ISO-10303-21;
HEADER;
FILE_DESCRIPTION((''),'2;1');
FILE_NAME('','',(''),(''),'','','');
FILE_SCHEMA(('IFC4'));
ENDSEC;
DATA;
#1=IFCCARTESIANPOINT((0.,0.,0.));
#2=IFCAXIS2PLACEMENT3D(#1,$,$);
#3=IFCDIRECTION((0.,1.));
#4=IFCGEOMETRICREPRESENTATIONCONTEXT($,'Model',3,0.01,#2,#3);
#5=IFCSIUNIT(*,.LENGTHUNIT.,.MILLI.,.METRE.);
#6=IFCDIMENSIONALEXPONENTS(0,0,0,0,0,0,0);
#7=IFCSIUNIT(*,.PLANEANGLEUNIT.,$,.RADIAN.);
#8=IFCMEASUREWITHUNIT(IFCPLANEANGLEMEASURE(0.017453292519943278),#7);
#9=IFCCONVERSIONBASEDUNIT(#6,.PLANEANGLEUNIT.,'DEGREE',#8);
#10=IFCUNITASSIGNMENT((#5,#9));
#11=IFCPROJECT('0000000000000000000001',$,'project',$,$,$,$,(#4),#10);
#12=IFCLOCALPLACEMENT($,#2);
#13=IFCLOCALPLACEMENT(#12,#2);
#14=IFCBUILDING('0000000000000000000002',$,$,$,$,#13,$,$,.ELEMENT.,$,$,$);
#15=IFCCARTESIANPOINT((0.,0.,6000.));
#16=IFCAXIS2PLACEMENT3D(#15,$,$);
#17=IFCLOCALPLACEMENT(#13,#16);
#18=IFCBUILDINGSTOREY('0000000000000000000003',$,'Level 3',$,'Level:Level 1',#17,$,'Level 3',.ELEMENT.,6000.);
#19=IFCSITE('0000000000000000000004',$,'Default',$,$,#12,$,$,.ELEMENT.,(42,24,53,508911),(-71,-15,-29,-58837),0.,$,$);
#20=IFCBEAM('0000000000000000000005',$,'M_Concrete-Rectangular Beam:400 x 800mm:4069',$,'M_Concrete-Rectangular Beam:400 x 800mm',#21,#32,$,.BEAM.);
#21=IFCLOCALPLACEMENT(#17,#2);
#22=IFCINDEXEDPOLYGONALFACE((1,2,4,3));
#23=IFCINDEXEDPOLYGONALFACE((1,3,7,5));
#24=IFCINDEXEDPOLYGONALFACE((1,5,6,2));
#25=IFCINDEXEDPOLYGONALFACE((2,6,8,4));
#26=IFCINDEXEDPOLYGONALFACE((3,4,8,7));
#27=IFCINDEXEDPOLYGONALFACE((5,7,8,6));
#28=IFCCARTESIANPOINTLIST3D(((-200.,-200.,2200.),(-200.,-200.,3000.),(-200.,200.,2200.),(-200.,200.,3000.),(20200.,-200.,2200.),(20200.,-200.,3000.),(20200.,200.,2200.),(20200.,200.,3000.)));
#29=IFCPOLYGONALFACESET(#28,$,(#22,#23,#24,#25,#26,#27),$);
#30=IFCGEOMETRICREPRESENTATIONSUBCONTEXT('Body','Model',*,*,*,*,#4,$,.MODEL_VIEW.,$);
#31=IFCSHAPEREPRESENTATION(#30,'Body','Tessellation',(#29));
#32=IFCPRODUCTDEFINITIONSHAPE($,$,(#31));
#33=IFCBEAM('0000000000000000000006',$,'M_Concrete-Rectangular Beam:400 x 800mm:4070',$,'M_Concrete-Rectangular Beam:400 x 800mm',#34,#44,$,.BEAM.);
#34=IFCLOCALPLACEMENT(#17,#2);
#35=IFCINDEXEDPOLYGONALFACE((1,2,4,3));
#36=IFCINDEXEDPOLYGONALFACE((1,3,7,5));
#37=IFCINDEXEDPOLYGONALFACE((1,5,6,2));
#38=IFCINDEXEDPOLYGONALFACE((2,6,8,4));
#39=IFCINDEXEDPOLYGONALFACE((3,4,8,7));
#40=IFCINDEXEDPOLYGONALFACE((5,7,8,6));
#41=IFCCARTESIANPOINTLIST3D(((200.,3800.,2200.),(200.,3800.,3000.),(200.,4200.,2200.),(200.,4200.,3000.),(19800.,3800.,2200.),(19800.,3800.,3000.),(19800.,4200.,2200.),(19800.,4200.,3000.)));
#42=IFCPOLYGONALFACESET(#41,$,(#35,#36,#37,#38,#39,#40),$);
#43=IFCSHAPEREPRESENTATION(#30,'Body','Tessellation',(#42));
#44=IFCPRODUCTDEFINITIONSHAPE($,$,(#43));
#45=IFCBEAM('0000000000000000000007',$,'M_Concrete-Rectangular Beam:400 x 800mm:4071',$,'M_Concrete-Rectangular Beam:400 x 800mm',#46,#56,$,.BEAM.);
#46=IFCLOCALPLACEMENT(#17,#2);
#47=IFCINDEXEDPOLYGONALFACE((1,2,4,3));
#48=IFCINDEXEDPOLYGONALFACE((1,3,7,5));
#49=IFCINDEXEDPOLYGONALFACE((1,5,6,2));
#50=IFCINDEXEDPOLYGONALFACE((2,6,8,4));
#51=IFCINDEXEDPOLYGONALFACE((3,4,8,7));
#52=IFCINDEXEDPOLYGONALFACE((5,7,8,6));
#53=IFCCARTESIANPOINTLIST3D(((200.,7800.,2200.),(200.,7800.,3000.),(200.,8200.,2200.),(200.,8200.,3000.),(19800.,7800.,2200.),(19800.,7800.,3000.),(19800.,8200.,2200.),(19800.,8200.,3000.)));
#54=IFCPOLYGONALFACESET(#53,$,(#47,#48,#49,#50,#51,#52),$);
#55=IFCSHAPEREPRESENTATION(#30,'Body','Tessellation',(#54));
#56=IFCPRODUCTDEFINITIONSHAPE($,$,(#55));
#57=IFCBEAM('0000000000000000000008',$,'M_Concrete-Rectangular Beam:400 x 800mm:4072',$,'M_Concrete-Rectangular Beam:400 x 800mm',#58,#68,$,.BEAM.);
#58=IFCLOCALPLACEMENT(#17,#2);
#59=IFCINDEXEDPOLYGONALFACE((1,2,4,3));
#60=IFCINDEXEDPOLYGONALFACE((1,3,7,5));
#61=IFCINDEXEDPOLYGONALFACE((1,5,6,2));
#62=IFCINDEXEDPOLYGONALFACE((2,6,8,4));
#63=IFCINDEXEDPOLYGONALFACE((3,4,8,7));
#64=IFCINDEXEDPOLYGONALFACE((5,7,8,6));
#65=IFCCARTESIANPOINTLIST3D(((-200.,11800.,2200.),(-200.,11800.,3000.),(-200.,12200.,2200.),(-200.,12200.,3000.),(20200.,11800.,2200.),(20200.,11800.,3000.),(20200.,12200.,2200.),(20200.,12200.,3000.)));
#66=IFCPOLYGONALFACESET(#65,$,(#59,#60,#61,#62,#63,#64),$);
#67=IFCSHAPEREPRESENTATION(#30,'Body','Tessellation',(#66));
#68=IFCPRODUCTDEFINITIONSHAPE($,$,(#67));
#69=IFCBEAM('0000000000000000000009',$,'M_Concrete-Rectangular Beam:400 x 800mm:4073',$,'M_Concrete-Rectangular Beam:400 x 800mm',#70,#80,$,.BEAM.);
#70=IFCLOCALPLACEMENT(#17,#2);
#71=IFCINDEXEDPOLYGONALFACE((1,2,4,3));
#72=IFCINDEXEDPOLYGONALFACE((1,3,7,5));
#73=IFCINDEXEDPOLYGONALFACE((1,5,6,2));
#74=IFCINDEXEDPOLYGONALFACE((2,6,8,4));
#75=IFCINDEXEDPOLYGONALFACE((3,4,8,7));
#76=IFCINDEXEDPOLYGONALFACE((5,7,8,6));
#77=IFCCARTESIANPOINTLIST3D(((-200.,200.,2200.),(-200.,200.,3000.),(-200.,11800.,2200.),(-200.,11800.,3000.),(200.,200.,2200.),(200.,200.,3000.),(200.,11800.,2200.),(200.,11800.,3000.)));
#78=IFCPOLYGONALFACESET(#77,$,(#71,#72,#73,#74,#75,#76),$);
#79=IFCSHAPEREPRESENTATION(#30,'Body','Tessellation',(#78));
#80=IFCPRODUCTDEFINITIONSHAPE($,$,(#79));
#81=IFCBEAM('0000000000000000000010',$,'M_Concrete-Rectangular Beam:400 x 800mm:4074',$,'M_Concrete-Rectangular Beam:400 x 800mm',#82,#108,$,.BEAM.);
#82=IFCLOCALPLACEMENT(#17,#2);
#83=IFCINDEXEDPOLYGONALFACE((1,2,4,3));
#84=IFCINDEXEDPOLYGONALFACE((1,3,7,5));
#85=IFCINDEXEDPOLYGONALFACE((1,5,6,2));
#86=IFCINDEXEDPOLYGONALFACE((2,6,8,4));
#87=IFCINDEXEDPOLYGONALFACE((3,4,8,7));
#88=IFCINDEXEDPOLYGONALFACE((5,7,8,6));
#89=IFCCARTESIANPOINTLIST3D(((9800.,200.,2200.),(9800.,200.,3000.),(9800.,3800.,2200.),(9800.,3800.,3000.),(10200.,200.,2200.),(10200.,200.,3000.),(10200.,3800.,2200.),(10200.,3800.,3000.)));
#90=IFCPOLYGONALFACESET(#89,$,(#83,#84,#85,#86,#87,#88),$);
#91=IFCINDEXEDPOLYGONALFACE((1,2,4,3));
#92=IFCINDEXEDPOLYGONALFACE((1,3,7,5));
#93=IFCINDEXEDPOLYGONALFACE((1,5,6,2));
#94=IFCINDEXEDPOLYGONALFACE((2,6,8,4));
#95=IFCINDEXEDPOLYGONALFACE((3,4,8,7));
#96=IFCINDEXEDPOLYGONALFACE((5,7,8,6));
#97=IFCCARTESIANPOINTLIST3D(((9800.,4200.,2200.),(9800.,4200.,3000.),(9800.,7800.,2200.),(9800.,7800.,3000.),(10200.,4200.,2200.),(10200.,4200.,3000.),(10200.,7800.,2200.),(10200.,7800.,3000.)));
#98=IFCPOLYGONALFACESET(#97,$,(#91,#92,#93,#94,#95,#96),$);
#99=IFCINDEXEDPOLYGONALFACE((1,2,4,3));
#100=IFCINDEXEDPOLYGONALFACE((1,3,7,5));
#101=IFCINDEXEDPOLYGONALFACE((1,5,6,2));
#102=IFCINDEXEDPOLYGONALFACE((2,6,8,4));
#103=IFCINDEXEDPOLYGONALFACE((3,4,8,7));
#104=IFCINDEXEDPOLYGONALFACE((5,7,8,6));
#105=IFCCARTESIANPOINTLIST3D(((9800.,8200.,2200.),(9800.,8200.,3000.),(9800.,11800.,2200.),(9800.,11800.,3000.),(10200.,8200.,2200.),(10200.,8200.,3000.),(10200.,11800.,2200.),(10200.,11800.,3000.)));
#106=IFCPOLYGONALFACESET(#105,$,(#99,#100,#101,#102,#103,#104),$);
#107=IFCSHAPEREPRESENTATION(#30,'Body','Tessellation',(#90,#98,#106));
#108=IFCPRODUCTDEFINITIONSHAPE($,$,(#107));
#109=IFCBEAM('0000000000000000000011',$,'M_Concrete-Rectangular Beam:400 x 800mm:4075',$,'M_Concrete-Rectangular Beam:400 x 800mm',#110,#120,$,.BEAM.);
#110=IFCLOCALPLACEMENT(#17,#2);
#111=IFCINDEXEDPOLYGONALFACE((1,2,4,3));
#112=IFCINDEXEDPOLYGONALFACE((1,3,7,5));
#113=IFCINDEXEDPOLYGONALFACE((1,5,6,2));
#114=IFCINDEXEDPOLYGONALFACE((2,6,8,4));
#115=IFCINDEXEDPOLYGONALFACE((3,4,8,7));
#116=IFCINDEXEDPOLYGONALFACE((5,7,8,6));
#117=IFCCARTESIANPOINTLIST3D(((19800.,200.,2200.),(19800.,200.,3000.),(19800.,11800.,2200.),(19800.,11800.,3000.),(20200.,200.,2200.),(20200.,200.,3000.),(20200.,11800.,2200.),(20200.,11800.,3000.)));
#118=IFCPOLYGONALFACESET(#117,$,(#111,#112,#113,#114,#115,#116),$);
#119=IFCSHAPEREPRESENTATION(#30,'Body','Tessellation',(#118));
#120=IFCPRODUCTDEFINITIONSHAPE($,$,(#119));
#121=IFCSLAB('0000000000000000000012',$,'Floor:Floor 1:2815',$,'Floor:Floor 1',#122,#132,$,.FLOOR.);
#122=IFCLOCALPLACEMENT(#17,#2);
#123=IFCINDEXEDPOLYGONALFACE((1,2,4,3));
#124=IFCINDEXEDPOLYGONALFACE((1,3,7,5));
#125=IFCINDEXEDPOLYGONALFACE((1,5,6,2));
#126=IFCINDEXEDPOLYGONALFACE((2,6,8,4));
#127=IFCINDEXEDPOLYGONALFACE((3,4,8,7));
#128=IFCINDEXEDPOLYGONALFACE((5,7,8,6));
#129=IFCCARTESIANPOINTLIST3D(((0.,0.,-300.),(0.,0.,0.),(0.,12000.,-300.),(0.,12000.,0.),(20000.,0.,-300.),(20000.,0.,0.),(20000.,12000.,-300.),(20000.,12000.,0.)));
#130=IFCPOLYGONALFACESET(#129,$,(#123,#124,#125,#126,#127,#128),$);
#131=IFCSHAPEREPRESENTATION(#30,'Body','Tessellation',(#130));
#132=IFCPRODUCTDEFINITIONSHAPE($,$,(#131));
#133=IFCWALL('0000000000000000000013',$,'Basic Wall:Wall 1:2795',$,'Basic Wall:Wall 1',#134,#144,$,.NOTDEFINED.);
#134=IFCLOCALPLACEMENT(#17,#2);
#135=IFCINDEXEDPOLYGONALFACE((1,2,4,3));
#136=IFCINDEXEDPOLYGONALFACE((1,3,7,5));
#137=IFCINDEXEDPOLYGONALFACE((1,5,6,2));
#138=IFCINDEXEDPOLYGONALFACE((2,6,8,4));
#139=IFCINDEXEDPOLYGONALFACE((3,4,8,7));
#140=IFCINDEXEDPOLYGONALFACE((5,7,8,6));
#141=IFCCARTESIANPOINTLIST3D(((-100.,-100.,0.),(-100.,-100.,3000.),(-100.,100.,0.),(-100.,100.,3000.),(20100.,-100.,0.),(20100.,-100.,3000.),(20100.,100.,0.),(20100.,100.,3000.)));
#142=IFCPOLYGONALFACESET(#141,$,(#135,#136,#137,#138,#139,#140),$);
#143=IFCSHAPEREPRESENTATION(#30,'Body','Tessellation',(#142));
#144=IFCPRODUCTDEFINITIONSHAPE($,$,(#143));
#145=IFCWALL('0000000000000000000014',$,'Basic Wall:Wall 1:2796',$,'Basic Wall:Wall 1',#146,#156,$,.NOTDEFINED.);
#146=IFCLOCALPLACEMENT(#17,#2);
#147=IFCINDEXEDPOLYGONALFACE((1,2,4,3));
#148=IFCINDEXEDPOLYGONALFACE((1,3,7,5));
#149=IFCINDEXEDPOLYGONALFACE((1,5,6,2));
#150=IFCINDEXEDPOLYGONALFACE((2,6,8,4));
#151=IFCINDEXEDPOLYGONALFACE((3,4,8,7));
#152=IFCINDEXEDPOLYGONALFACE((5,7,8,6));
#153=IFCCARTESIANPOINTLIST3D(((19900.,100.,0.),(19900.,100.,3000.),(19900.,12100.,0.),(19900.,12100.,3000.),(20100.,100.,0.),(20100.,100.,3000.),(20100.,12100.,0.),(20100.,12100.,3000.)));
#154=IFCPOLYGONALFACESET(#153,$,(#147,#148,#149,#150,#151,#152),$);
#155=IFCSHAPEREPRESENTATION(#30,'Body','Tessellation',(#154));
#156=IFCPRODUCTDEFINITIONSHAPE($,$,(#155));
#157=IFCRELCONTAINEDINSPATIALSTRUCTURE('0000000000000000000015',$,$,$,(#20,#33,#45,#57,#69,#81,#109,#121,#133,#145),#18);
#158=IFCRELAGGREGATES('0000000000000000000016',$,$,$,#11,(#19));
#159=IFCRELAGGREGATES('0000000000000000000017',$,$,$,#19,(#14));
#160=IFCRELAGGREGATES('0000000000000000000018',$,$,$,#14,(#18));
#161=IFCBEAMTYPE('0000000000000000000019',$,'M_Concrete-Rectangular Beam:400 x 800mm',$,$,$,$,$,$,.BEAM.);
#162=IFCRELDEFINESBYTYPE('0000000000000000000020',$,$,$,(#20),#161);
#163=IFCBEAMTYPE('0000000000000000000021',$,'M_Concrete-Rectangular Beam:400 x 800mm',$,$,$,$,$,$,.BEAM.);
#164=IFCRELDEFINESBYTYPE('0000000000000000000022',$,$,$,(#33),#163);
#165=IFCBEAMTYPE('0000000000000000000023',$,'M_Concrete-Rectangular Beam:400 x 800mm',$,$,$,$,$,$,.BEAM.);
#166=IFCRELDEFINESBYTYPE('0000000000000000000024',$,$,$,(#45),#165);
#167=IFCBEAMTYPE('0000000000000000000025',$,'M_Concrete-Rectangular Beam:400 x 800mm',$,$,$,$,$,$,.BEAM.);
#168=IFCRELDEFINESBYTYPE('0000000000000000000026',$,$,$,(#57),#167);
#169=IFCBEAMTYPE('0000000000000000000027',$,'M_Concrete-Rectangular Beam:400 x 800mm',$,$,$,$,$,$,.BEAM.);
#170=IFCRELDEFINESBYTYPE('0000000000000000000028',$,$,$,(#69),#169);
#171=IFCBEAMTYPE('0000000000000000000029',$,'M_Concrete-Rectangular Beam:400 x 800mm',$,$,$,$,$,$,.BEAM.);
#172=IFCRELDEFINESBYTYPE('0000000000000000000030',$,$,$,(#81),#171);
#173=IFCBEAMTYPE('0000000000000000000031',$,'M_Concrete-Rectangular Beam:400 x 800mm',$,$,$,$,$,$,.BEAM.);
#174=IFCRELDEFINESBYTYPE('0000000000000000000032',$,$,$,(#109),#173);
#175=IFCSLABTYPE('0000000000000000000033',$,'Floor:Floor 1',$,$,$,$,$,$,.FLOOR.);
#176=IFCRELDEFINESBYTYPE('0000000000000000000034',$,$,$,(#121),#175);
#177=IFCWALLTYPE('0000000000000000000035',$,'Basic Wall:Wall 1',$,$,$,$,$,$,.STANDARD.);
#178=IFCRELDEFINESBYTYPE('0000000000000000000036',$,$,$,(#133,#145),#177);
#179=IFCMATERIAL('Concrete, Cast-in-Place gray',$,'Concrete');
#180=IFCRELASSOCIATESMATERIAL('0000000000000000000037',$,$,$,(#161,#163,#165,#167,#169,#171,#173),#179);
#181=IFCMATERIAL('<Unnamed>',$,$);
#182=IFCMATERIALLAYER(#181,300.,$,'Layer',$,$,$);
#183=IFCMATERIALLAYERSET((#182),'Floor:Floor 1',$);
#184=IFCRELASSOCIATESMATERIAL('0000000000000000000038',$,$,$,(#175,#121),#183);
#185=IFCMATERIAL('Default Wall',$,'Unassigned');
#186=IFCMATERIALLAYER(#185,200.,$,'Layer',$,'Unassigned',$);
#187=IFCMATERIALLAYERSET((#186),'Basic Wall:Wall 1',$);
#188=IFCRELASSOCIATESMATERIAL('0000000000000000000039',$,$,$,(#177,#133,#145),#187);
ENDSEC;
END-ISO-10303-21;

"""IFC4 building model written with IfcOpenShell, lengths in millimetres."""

from ifc_helpers import new_model, entity, si_unit, converted_unit, direction, frame, frame_2d, origin, origin_2d_with_axis, place, context, subcontext, project, spatial, rectangle, extrude, source, transform, mapped, material, layer, layer_set, layer_usage, material_profile, profile_set, type_object, type_shapes, element, save


model = new_model("IFC4")

# Units and contexts
model_context = context("Model", 3, precision=0.01, world=origin(), true_north=direction((0.0, 1.0)))
body_context = subcontext(model_context, "Body", "Model", "MODEL_VIEW")
ifc_project = project(units=[si_unit("LENGTHUNIT", "METRE", prefix="MILLI"), converted_unit("PLANEANGLEUNIT", "DEGREE", entity("IfcPlaneAngleMeasure", 0.017453292519943278), si_unit("PLANEANGLEUNIT", "RADIAN"), dimensions=[0, 0, 0, 0, 0, 0, 0])], contexts=[model_context])

# Site, building, storey
site_placement = place(None, origin())
site = spatial("IfcSite", under=ifc_project, at=site_placement, Name="Default", CompositionType="ELEMENT", RefLatitude=(42, 24, 53, 508911), RefLongitude=(-71, -15, -29, -58837), RefElevation=0.0)
building_placement = place(site_placement, origin())
building = spatial("IfcBuilding", under=site, at=building_placement, CompositionType="ELEMENT")
storey_placement = place(building_placement, frame((0.0, 0.0, 6000.0)))
storey = spatial("IfcBuildingStorey", under=building, at=storey_placement, Name="Level 3", ObjectType="Level:Level 1", LongName="Level 3", CompositionType="ELEMENT", Elevation=6000.0)

# Beams
ifc_material_1 = material(Name="Concrete, Cast-in-Place gray", Category="Concrete")
ifc_material_profile = material_profile(ifc_material_1, rectangle(XDim=800.0, YDim=400.0, at=origin_2d_with_axis()), Name="400 x 800mm")
ifc_profile_set = profile_set([ifc_material_profile], Name="400 x 800mm")
beam_type_1 = type_object("IfcBeamType", Name="M_Concrete-Rectangular Beam:400 x 800mm", PredefinedType="BEAM", material=ifc_profile_set)
shared_shape_1 = source(origin(), body_context, "Body", "SweptSolid", [
    extrude(rectangle(XDim=800.0, YDim=400.0, at=origin_2d_with_axis()), frame((-200.0, 0.0, 8600.0), z_axis=(1.0, 0.0, 0.0), x_axis=(0.0, 0.0, -1.0)), (0.0, 0.0, 1.0), 20400.0),
])
type_shapes(beam_type_1, [shared_shape_1])
beam_1_placement = place(storey_placement, frame((0.0, 0.0, -6000.0)))
element("IfcBeam", 1, at=beam_1_placement, inside=storey, type_object=beam_type_1, Name="M_Concrete-Rectangular Beam:400 x 800mm:4069", ObjectType="M_Concrete-Rectangular Beam:400 x 800mm", PredefinedType="BEAM", context=body_context, shape_type="MappedRepresentation", body=[
    mapped(shared_shape_1, transform((0.0, 0.0, 0.0), scale=1.0)),
])
beam_type_2 = type_object("IfcBeamType", Name="M_Concrete-Rectangular Beam:400 x 800mm", PredefinedType="BEAM", material=ifc_profile_set)
shared_shape_2 = source(origin(), body_context, "Body", "SweptSolid", [
    extrude(rectangle(XDim=800.0, YDim=400.0, at=origin_2d_with_axis()), frame((200.0, 4000.0, 8600.0), z_axis=(1.0, 0.0, 0.0), x_axis=(0.0, 0.0, -1.0)), (0.0, 0.0, 1.0), 19600.0),
])
type_shapes(beam_type_2, [shared_shape_2])
beam_2_placement = place(storey_placement, frame((0.0, 0.0, -6000.0)))
element("IfcBeam", 2, at=beam_2_placement, inside=storey, type_object=beam_type_2, Name="M_Concrete-Rectangular Beam:400 x 800mm:4070", ObjectType="M_Concrete-Rectangular Beam:400 x 800mm", PredefinedType="BEAM", context=body_context, shape_type="MappedRepresentation", body=[
    mapped(shared_shape_2, transform((0.0, 0.0, 0.0), scale=1.0)),
])
beam_type_3 = type_object("IfcBeamType", Name="M_Concrete-Rectangular Beam:400 x 800mm", PredefinedType="BEAM", material=ifc_profile_set)
shared_shape_3 = source(origin(), body_context, "Body", "SweptSolid", [
    extrude(rectangle(XDim=800.0, YDim=400.0, at=frame_2d((0.0, 0.0), x_axis=(1.0, 0.0))), frame((200.0, 8000.0, 8600.0), z_axis=(1.0, 0.0, 0.0), x_axis=(0.0, 0.0, -1.0)), (0.0, 0.0, 1.0), 19600.0),
])
type_shapes(beam_type_3, [shared_shape_3])
beam_3_placement = place(storey_placement, frame((0.0, 0.0, -6000.0)))
element("IfcBeam", 3, at=beam_3_placement, inside=storey, type_object=beam_type_3, Name="M_Concrete-Rectangular Beam:400 x 800mm:4071", ObjectType="M_Concrete-Rectangular Beam:400 x 800mm", PredefinedType="BEAM", context=body_context, shape_type="MappedRepresentation", body=[
    mapped(shared_shape_3, transform((0.0, 0.0, 0.0), scale=1.0)),
])
beam_type_4 = type_object("IfcBeamType", Name="M_Concrete-Rectangular Beam:400 x 800mm", PredefinedType="BEAM", material=ifc_profile_set)
shared_shape_4 = source(origin(), body_context, "Body", "SweptSolid", [
    extrude(rectangle(XDim=800.0, YDim=400.0, at=frame_2d((0.0, 0.0), x_axis=(1.0, 0.0))), frame((-200.0, 12000.0, 8600.0), z_axis=(1.0, 0.0, 0.0), x_axis=(0.0, 0.0, -1.0)), (0.0, 0.0, 1.0), 20400.0),
])
type_shapes(beam_type_4, [shared_shape_4])
beam_4_placement = place(storey_placement, frame((0.0, 0.0, -6000.0)))
element("IfcBeam", 4, at=beam_4_placement, inside=storey, type_object=beam_type_4, Name="M_Concrete-Rectangular Beam:400 x 800mm:4072", ObjectType="M_Concrete-Rectangular Beam:400 x 800mm", PredefinedType="BEAM", context=body_context, shape_type="MappedRepresentation", body=[
    mapped(shared_shape_4, transform((0.0, 0.0, 0.0), scale=1.0)),
])
beam_type_5 = type_object("IfcBeamType", Name="M_Concrete-Rectangular Beam:400 x 800mm", PredefinedType="BEAM", material=ifc_profile_set)
shared_shape_5 = source(origin(), body_context, "Body", "SweptSolid", [
    extrude(rectangle(XDim=800.0, YDim=400.0, at=frame_2d((0.0, 0.0), x_axis=(0.0, 1.0))), frame((0.0, 200.0, 8600.0), z_axis=(0.0, 1.0, 0.0), x_axis=(-1.0, 0.0, 0.0)), (0.0, 0.0, 1.0), 11600.0),
])
type_shapes(beam_type_5, [shared_shape_5])
beam_5_placement = place(storey_placement, frame((0.0, 0.0, -6000.0)))
element("IfcBeam", 5, at=beam_5_placement, inside=storey, type_object=beam_type_5, Name="M_Concrete-Rectangular Beam:400 x 800mm:4073", ObjectType="M_Concrete-Rectangular Beam:400 x 800mm", PredefinedType="BEAM", context=body_context, shape_type="MappedRepresentation", body=[
    mapped(shared_shape_5, transform((0.0, 0.0, 0.0), scale=1.0)),
])
beam_type_6 = type_object("IfcBeamType", Name="M_Concrete-Rectangular Beam:400 x 800mm", PredefinedType="BEAM", material=ifc_profile_set)
shared_shape_6 = source(origin(), body_context, "Body", "SweptSolid", [
    extrude(rectangle(XDim=800.0, YDim=400.0, at=frame_2d((0.0, 0.0), x_axis=(0.0, 1.0))), frame((10000.0, 200.0, 8600.0), z_axis=(0.0, 1.0, 0.0), x_axis=(-1.0, 0.0, 0.0)), (0.0, 0.0, 1.0), 3600.0),
    extrude(rectangle(XDim=800.0, YDim=400.0, at=frame_2d((0.0, 0.0), x_axis=(0.0, 1.0))), frame((10000.0, 4200.0, 8600.0), z_axis=(0.0, 1.0, 0.0), x_axis=(-1.0, 0.0, 0.0)), (0.0, 0.0, 1.0), 3600.0),
    extrude(rectangle(XDim=800.0, YDim=400.0, at=frame_2d((0.0, 0.0), x_axis=(0.0, 1.0))), frame((10000.0, 8200.0, 8600.0), z_axis=(0.0, 1.0, 0.0), x_axis=(-1.0, 0.0, 0.0)), (0.0, 0.0, 1.0), 3600.0),
])
type_shapes(beam_type_6, [shared_shape_6])
beam_6_placement = place(storey_placement, frame((0.0, 0.0, -6000.0)))
element("IfcBeam", 6, at=beam_6_placement, inside=storey, type_object=beam_type_6, Name="M_Concrete-Rectangular Beam:400 x 800mm:4074", ObjectType="M_Concrete-Rectangular Beam:400 x 800mm", PredefinedType="BEAM", context=body_context, shape_type="MappedRepresentation", body=[
    mapped(shared_shape_6, transform((0.0, 0.0, 0.0), scale=1.0)),
])
beam_type_7 = type_object("IfcBeamType", Name="M_Concrete-Rectangular Beam:400 x 800mm", PredefinedType="BEAM", material=ifc_profile_set)
shared_shape_7 = source(origin(), body_context, "Body", "SweptSolid", [
    extrude(rectangle(XDim=800.0, YDim=400.0, at=frame_2d((0.0, 0.0), x_axis=(0.0, 1.0))), frame((20000.0, 200.0, 8600.0), z_axis=(0.0, 1.0, 0.0), x_axis=(-1.0, 0.0, 0.0)), (0.0, 0.0, 1.0), 11600.0),
])
type_shapes(beam_type_7, [shared_shape_7])
beam_7_placement = place(storey_placement, frame((0.0, 0.0, -6000.0)))
element("IfcBeam", 7, at=beam_7_placement, inside=storey, type_object=beam_type_7, Name="M_Concrete-Rectangular Beam:400 x 800mm:4075", ObjectType="M_Concrete-Rectangular Beam:400 x 800mm", PredefinedType="BEAM", context=body_context, shape_type="MappedRepresentation", body=[
    mapped(shared_shape_7, transform((0.0, 0.0, 0.0), scale=1.0)),
])

# Slab
ifc_material_2 = material(Name="<Unnamed>")
ifc_layer_1 = layer(ifc_material_2, 300.0, Name="Layer")
ifc_layer_set_1 = layer_set([ifc_layer_1], Name="Floor:Floor 1")
ifc_layer_usage_1 = layer_usage(ifc_layer_set_1, "AXIS3", "POSITIVE", 0.0)
slab_type = type_object("IfcSlabType", Name="Floor:Floor 1", PredefinedType="FLOOR", material=ifc_layer_set_1)
slab_placement = place(storey_placement, origin())
element("IfcSlab", 8, at=slab_placement, inside=storey, type_object=slab_type, material=ifc_layer_usage_1, Name="Floor:Floor 1:2815", ObjectType="Floor:Floor 1", PredefinedType="FLOOR", context=body_context, shape_type="SweptSolid", body=[
    extrude(rectangle(XDim=12000.0, YDim=20000.0, at=origin_2d_with_axis()), frame((10000.0, 6000.0, 0.0), z_axis=(0.0, 0.0, -1.0), x_axis=(0.0, 1.0, 0.0)), (0.0, 0.0, 1.0), 300.0),
])

# Walls
ifc_material_3 = material(Name="Default Wall", Category="Unassigned")
ifc_layer_2 = layer(ifc_material_3, 200.0, Name="Layer", Category="Unassigned")
ifc_layer_set_2 = layer_set([ifc_layer_2], Name="Basic Wall:Wall 1")
ifc_layer_usage_2 = layer_usage(ifc_layer_set_2, "AXIS2", "NEGATIVE", 100.0)
wall_type = type_object("IfcWallType", Name="Basic Wall:Wall 1", PredefinedType="STANDARD", material=ifc_layer_set_2)
wall_1_placement = place(storey_placement, frame((-100.0, 0.0, 0.0)))
element("IfcWall", 9, at=wall_1_placement, inside=storey, type_object=wall_type, material=ifc_layer_usage_2, Name="Basic Wall:Wall 1:2795", ObjectType="Basic Wall:Wall 1", PredefinedType="NOTDEFINED", context=body_context, shape_type="SweptSolid", body=[
    extrude(rectangle(XDim=20200.0, YDim=200.0, at=frame_2d((10100.0, 0.0), x_axis=(-1.0, 0.0))), origin(), (0.0, 0.0, 1.0), 3000.0),
])
ifc_layer_usage_3 = layer_usage(ifc_layer_set_2, "AXIS2", "NEGATIVE", 100.0)
wall_2_placement = place(storey_placement, frame((20000.0, 100.0, 0.0), z_axis=(0.0, 0.0, 1.0), x_axis=(0.0, 1.0, 0.0)))
element("IfcWall", 10, at=wall_2_placement, inside=storey, type_object=wall_type, material=ifc_layer_usage_3, Name="Basic Wall:Wall 1:2796", ObjectType="Basic Wall:Wall 1", PredefinedType="NOTDEFINED", context=body_context, shape_type="SweptSolid", body=[
    extrude(rectangle(XDim=12000.0, YDim=200.0, at=frame_2d((6000.0, 0.0), x_axis=(-1.0, 0.0))), origin(), (0.0, 0.0, 1.0), 3000.0),
])

save(model, "model.ifc")
